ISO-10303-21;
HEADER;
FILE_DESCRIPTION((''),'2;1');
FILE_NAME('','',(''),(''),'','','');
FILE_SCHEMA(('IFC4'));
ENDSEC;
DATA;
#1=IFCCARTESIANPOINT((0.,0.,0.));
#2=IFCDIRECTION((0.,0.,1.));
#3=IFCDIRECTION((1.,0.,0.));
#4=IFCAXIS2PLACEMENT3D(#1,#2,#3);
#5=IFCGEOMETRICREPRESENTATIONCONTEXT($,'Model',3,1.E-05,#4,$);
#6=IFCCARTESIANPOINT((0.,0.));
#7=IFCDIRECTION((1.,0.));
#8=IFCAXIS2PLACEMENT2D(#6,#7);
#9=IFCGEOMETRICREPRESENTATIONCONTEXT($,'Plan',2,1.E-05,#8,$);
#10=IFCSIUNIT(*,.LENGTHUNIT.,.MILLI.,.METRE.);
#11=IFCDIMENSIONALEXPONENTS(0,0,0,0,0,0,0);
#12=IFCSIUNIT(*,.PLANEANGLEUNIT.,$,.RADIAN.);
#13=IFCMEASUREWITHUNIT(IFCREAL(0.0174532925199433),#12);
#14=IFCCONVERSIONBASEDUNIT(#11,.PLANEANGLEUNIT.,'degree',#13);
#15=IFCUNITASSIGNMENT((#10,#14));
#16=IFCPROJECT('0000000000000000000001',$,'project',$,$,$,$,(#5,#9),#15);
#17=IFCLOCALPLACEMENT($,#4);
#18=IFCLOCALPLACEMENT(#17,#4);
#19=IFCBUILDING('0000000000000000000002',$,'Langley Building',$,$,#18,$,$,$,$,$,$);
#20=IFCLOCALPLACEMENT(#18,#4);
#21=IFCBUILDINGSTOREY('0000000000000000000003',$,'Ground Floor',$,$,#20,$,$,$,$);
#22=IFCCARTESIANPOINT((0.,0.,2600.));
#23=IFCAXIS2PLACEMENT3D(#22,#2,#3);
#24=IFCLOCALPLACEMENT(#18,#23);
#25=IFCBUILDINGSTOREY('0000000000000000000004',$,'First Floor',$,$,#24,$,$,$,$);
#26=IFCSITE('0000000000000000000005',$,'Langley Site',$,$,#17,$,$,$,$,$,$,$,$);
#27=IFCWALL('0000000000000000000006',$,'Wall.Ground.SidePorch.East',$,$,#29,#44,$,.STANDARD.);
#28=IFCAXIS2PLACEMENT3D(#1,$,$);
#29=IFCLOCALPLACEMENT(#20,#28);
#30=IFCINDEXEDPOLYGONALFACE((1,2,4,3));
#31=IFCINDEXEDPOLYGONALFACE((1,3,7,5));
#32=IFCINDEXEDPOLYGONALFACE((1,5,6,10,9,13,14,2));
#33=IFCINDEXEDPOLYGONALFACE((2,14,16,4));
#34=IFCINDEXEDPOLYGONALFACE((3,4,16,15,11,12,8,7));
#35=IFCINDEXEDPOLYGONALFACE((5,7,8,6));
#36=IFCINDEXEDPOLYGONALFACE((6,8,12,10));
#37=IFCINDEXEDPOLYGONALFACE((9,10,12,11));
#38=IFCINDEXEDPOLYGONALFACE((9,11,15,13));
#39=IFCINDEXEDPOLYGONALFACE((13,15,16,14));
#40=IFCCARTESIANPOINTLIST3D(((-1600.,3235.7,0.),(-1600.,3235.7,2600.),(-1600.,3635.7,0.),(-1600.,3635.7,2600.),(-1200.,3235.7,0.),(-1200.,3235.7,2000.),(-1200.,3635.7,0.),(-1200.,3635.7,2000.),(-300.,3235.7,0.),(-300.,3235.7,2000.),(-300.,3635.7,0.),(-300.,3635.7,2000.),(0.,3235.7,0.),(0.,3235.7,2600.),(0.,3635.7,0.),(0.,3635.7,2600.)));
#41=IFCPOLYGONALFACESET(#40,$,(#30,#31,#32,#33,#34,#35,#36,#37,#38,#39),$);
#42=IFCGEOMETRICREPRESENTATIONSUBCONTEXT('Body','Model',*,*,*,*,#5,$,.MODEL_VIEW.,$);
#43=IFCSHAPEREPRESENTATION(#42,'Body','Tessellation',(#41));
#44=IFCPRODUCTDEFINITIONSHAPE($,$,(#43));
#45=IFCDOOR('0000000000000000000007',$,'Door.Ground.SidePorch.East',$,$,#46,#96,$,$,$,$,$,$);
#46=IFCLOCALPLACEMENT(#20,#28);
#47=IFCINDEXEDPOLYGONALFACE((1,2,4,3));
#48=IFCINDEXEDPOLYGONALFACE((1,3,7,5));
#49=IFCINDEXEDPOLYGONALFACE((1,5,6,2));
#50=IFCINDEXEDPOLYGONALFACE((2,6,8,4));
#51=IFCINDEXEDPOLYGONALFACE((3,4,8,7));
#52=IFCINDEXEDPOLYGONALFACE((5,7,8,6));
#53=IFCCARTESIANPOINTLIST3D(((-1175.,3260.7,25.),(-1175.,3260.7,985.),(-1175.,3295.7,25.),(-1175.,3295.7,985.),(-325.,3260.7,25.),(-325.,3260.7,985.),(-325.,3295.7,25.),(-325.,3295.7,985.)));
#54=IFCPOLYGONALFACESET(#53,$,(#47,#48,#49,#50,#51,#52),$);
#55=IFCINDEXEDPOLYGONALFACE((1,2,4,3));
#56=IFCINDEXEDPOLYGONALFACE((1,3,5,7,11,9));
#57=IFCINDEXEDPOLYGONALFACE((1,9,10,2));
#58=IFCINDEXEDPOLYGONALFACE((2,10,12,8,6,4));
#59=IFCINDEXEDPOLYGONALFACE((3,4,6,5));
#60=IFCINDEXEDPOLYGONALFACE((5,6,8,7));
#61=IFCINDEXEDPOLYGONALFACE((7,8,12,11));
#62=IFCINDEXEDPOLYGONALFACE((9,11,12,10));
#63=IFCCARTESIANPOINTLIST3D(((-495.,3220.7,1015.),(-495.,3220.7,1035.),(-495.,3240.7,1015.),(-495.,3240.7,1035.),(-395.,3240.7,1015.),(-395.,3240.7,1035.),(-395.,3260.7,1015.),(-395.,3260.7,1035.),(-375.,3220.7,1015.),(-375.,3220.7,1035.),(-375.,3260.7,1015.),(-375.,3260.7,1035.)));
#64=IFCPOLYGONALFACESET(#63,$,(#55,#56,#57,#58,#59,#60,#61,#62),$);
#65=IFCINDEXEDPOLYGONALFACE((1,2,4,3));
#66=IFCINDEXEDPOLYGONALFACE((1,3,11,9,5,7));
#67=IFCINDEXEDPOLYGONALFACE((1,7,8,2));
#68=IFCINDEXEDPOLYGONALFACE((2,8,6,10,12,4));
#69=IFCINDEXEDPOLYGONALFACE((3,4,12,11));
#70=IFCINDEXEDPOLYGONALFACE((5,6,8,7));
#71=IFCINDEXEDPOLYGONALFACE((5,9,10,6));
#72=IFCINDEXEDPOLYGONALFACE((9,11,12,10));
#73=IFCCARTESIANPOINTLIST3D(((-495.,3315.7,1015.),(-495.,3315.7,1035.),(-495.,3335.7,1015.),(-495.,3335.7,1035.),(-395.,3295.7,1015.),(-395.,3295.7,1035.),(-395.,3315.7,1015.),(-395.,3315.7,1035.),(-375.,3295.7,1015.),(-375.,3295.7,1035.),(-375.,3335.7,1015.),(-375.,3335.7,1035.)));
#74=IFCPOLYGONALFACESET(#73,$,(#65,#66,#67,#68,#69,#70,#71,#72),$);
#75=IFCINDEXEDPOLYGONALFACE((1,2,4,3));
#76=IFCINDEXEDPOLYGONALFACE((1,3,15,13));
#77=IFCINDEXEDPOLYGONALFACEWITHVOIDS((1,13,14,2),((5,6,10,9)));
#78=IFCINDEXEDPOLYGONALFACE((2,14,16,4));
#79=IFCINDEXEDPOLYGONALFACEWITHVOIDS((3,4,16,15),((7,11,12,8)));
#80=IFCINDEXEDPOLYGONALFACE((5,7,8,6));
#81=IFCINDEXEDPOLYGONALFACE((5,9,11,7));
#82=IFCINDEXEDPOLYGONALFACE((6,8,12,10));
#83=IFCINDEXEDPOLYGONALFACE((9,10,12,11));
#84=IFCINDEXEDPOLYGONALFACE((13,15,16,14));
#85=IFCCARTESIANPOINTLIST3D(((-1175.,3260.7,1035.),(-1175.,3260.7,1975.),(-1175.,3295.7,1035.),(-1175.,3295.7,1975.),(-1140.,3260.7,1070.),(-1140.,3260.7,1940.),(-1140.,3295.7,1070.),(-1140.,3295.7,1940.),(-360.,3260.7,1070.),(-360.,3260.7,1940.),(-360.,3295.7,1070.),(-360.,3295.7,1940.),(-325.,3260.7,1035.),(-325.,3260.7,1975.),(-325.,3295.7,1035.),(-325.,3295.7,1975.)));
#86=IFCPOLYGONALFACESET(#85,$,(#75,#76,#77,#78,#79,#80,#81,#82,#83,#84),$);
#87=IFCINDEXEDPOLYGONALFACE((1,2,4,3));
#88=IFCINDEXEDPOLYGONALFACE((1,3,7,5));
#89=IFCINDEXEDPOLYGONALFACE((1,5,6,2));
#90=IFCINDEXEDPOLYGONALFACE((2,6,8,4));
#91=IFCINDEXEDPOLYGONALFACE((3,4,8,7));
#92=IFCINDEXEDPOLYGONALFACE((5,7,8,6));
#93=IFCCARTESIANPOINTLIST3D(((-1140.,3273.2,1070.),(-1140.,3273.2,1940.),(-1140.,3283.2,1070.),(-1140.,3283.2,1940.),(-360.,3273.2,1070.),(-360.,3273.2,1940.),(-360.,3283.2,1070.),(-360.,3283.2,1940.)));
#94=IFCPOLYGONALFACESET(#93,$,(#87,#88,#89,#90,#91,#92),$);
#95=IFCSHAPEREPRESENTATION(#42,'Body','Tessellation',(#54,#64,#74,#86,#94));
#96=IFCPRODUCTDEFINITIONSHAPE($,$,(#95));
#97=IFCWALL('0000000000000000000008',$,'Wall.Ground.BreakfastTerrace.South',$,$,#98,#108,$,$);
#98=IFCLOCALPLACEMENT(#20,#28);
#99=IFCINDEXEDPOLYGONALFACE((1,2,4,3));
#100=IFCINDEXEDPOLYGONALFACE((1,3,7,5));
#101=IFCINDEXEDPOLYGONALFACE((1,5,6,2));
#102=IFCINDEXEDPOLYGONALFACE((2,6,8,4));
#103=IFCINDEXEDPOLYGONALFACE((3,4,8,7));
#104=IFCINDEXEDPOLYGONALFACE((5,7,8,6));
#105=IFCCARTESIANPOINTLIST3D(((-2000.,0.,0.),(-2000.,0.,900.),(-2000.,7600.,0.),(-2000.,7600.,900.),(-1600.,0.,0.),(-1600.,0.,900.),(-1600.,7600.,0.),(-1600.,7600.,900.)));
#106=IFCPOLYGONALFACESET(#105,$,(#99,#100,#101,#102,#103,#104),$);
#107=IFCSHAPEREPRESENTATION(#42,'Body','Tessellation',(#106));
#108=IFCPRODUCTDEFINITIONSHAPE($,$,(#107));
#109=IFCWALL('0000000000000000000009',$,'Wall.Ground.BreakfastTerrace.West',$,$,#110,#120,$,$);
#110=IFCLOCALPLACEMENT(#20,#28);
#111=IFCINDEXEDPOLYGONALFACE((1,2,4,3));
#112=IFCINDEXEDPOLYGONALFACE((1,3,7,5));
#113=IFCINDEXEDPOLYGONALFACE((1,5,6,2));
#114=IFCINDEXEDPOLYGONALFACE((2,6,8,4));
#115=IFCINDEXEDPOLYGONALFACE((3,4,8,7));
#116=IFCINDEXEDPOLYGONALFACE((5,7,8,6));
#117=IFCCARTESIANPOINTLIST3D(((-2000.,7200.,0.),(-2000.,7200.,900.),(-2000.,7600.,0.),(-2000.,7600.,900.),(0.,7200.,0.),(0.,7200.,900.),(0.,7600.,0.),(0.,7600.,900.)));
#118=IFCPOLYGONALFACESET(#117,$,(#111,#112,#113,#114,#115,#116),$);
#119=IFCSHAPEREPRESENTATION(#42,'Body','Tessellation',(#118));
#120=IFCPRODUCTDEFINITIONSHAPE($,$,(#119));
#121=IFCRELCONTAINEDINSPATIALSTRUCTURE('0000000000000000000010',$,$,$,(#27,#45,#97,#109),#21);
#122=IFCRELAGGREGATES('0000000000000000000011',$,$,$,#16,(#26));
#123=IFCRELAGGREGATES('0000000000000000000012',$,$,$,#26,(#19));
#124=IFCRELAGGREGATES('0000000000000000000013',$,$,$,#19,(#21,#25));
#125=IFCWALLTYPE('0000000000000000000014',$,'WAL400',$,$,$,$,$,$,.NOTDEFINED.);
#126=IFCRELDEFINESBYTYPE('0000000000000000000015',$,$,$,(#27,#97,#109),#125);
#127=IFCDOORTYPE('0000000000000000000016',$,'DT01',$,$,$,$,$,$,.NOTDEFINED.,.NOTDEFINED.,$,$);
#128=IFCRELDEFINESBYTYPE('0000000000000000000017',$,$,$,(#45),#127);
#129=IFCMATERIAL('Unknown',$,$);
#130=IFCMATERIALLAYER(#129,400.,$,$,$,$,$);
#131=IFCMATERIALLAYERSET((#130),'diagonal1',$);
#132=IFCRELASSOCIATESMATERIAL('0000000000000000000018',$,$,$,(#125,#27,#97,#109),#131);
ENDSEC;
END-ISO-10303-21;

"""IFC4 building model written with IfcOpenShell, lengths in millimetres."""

from ifc_helpers import new_model, entity, si_unit, converted_unit, frame, origin_with_axes, origin_2d_with_axis, place, context, subcontext, project, spatial, line, indexed_curve, outline, extrude, shape, source, transform, mapped, material, layer, layer_set, layer_usage, type_object, type_shapes, element, fill, save


model = new_model("IFC4")

# Units and contexts
model_context = context("Model", 3, precision=1e-05, world=origin_with_axes())
plan_context = context("Plan", 2, precision=1e-05, world=origin_2d_with_axis())
body_context_1 = subcontext(model_context, "Body", "Model", "MODEL_VIEW")
body_context_2 = subcontext(plan_context, "Body", "Plan", "PLAN_VIEW")
ifc_project = project(units=[si_unit("LENGTHUNIT", "METRE", prefix="MILLI"), converted_unit("PLANEANGLEUNIT", "degree", entity("IfcReal", 0.0174532925199433), si_unit("PLANEANGLEUNIT", "RADIAN"), dimensions=[0, 0, 0, 0, 0, 0, 0])], contexts=[model_context, plan_context])

# Site, building, storey
site_placement = place(None, origin_with_axes())
site = spatial("IfcSite", under=ifc_project, at=site_placement, Name="Langley Site")
building_placement = place(site_placement, origin_with_axes())
building = spatial("IfcBuilding", under=site, at=building_placement, Name="Langley Building")
storey_1_placement = place(building_placement, origin_with_axes())
storey_1 = spatial("IfcBuildingStorey", under=building, at=storey_1_placement, Name="Ground Floor")

# Shared definitions
ifc_material = material(Name="Unknown")

# Shared definitions
storey_2_placement = place(building_placement, frame((0.0, 0.0, 2600.0), z_axis=(0.0, 0.0, 1.0), x_axis=(1.0, 0.0, 0.0)))
storey_2 = spatial("IfcBuildingStorey", under=building, at=storey_2_placement, Name="First Floor")

# Shared definitions
ifc_layer_1 = layer(ifc_material, 400.0)
ifc_layer_set_1 = layer_set([ifc_layer_1], Name="diagonal1")
wall_type_1 = type_object("IfcWallType", Name="WAL400", PredefinedType="NOTDEFINED", material=ifc_layer_set_1)

# Wall, opening, door
ifc_layer_usage_1 = layer_usage(ifc_layer_set_1, "AXIS2", "POSITIVE", 0.0)
wall_1_placement = place(storey_1_placement, frame((-1600.0, 3235.7, 0.0), z_axis=(0.0, 0.0, 1.0), x_axis=(1.0, 0.0, 0.0)))
wall_1 = element("IfcWall", 1, at=wall_1_placement, inside=storey_1, type_object=wall_type_1, material=ifc_layer_usage_1, Name="Wall.Ground.SidePorch.East", PredefinedType="STANDARD", context=body_context_1, shape_type="SweptSolid", body=[
    extrude(outline(indexed_curve([(0.0, 0.0), (0.0, 400.0), (1600.0, 400.0), (1600.0, 0.0)], segments=[line(1, 2, 3, 4, 1)])), origin_with_axes(), (0.0, 0.0, 1.0), 2600.0),
])
shared_shape_1 = source(origin_with_axes(), body_context_1, "Body", "SweptSolid", [
    extrude(outline(indexed_curve([(0.0, 0.0), (900.0, 0.0), (900.0, 2000.0), (0.0, 2000.0)], segments=[line(1, 2, 3, 4, 1)])), frame((0.0, -600.0, 0.0), z_axis=(0.0, -1.0, 0.0), x_axis=(1.0, 0.0, 0.0)), (0.0, 0.0, -1.0), 1200.0),
])
opening_1_placement = place(wall_1_placement, frame((400.0, 0.0, 0.0), z_axis=(0.0, 0.0, 1.0), x_axis=(1.0, 0.0, 0.0)))
opening_1 = element("IfcOpeningElement", 2, at=opening_1_placement, cuts=wall_1, PredefinedType="OPENING", context=body_context_1, shape_type="MappedRepresentation", body=[
    mapped(shared_shape_1, transform((0.0, 0.0, 0.0), x_axis=(1.0, 0.0, 0.0), y_axis=(0.0, 1.0, 0.0), z_axis=(0.0, 0.0, 1.0), scale=1.0)),
])
door_type_1 = type_object("IfcDoorType", Name="DT01", OperationType="NOTDEFINED", PredefinedType="NOTDEFINED")
shared_shape_2 = source(origin_with_axes(), body_context_1, "Body", "SweptSolid", [
    extrude(outline(indexed_curve([(0.0, 0.0), (850.0, 0.0), (850.0, 35.0), (0.0, 35.0)], segments=[line(1, 2, 3, 4, 1)])), frame((25.0, 25.0, 25.0), z_axis=(0.0, 0.0, 1.0), x_axis=(1.0, 0.0, 0.0)), (0.0, 0.0, 1.0), 960.0),
    extrude(outline(indexed_curve([(0.0, 0.0), (0.0, -40.0), (-120.0, -40.0), (-120.0, -20.0), (-20.0, -20.0), (-20.0, 0.0)], segments=[line(1, 2, 3, 4, 5, 6, 1)])), frame((825.0, 25.0, 1015.0), z_axis=(0.0, 0.0, 1.0), x_axis=(1.0, 0.0, 0.0)), (0.0, 0.0, 1.0), 20.0),
    extrude(outline(indexed_curve([(0.0, 0.0), (0.0, 40.0), (-120.0, 40.0), (-120.0, 20.0), (-20.0, 20.0), (-20.0, 0.0)], segments=[line(1, 2, 3, 4, 5, 6, 1)])), frame((825.0, 60.0, 1015.0), z_axis=(0.0, 0.0, 1.0), x_axis=(1.0, 0.0, 0.0)), (0.0, 0.0, 1.0), 20.0),
    extrude(outline(indexed_curve([(0.0, 0.0), (850.0, 0.0), (850.0, 940.0), (0.0, 940.0)], segments=[line(1, 2, 3, 4, 1)]), holes=[indexed_curve([(35.0, 35.0), (815.0, 35.0), (815.0, 905.0), (35.0, 905.0)], segments=[line(1, 2, 3, 4, 1)])]), frame((25.0, 25.0, 1035.0), z_axis=(0.0, -1.0, 0.0), x_axis=(1.0, 0.0, 0.0)), (0.0, 0.0, -1.0), 35.0),
    extrude(outline(indexed_curve([(35.0, 35.0), (815.0, 35.0), (815.0, 905.0), (35.0, 905.0)], segments=[line(1, 2, 3, 4, 1)])), frame((25.0, 37.5, 1035.0), z_axis=(0.0, -1.0, 0.0), x_axis=(1.0, 0.0, 0.0)), (0.0, 0.0, -1.0), 10.0),
])
shared_shape_3 = source(origin_with_axes(), body_context_2, "Body", "Curve2D", [
    entity("IfcIndexedPolyCurve", entity("IfcCartesianPointList2D", [[0.0, 0.0], [0.0, 50.0], [25.0, 50.0], [25.0, 25.0], [50.0, 25.0], [50.0, 0.0]]), [entity("IfcLineIndex", [1, 2, 3, 4, 5, 6, 1])]),
    entity("IfcIndexedPolyCurve", entity("IfcCartesianPointList2D", [[900.0, 0.0], [900.0, 50.0], [875.0, 50.0], [875.0, 25.0], [850.0, 25.0], [850.0, 0.0]]), [entity("IfcLineIndex", [1, 2, 3, 4, 5, 6, 1])]),
    entity("IfcTrimmedCurve", entity("IfcEllipse", entity("IfcAxis2Placement2D", entity("IfcCartesianPoint", [60.0, 50.0]), entity("IfcDirection", [1.0, 0.0])), 815.0, 850.0), [entity("IfcCartesianPoint", [875.0, 50.0])], [entity("IfcCartesianPoint", [60.0, 900.0])], True, "CARTESIAN"),
    entity("IfcIndexedPolyCurve", entity("IfcCartesianPointList2D", [[25.0, 50.0], [60.0, 50.0], [60.0, 900.0], [25.0, 900.0]]), [entity("IfcLineIndex", [1, 2, 3, 4, 1])]),
])
type_shapes(door_type_1, [shared_shape_2, shared_shape_3])
door_1_placement = place(opening_1_placement, origin_with_axes())
door_1 = element("IfcDoor", 3, at=door_1_placement, inside=storey_1, type_object=door_type_1, Name="Door.Ground.SidePorch.East", shapes=[
    shape(body_context_1, "Body", "MappedRepresentation", [mapped(shared_shape_2, transform((0.0, 0.0, 0.0), x_axis=(1.0, 0.0, 0.0), y_axis=(0.0, 1.0, 0.0), z_axis=(0.0, 0.0, 1.0), scale=1.0))]),
    shape(body_context_2, "Body", "MappedRepresentation", [mapped(shared_shape_3, transform((0.0, 0.0, 0.0), x_axis=(1.0, 0.0, 0.0), y_axis=(0.0, 1.0, 0.0), z_axis=(0.0, 0.0, 1.0), scale=1.0))]),
])
fill(opening_1, door_1)

# Walls
ifc_layer_usage_2 = layer_usage(ifc_layer_set_1, "AXIS2", "POSITIVE", 0.0)
wall_2_placement = place(storey_1_placement, frame((-1600.0, 0.0, 0.0), z_axis=(0.0, 0.0, 1.0), x_axis=(0.0, 1.0, 0.0)))
element("IfcWall", 4, at=wall_2_placement, inside=storey_1, type_object=wall_type_1, material=ifc_layer_usage_2, Name="Wall.Ground.BreakfastTerrace.South", context=body_context_1, shape_type="SweptSolid", body=[
    extrude(outline(indexed_curve([(0.0, 0.0), (0.0, 400.0), (7600.0, 400.0), (7600.0, 0.0)], segments=[line(1, 2, 3, 4, 1)])), origin_with_axes(), (0.0, 0.0, 1.0), 900.0),
])
ifc_layer_usage_3 = layer_usage(ifc_layer_set_1, "AXIS2", "POSITIVE", 0.0)
wall_3_placement = place(storey_1_placement, frame((-2000.0, 7200.0, 0.0), z_axis=(0.0, 0.0, 1.0), x_axis=(1.0, 0.0, 0.0)))
element("IfcWall", 5, at=wall_3_placement, inside=storey_1, type_object=wall_type_1, material=ifc_layer_usage_3, Name="Wall.Ground.BreakfastTerrace.West", context=body_context_1, shape_type="SweptSolid", body=[
    extrude(outline(indexed_curve([(0.0, 0.0), (0.0, 400.0), (2000.0, 400.0), (2000.0, 0.0)], segments=[line(1, 2, 3, 4, 1)])), origin_with_axes(), (0.0, 0.0, 1.0), 900.0),
])

save(model, "model.ifc")
